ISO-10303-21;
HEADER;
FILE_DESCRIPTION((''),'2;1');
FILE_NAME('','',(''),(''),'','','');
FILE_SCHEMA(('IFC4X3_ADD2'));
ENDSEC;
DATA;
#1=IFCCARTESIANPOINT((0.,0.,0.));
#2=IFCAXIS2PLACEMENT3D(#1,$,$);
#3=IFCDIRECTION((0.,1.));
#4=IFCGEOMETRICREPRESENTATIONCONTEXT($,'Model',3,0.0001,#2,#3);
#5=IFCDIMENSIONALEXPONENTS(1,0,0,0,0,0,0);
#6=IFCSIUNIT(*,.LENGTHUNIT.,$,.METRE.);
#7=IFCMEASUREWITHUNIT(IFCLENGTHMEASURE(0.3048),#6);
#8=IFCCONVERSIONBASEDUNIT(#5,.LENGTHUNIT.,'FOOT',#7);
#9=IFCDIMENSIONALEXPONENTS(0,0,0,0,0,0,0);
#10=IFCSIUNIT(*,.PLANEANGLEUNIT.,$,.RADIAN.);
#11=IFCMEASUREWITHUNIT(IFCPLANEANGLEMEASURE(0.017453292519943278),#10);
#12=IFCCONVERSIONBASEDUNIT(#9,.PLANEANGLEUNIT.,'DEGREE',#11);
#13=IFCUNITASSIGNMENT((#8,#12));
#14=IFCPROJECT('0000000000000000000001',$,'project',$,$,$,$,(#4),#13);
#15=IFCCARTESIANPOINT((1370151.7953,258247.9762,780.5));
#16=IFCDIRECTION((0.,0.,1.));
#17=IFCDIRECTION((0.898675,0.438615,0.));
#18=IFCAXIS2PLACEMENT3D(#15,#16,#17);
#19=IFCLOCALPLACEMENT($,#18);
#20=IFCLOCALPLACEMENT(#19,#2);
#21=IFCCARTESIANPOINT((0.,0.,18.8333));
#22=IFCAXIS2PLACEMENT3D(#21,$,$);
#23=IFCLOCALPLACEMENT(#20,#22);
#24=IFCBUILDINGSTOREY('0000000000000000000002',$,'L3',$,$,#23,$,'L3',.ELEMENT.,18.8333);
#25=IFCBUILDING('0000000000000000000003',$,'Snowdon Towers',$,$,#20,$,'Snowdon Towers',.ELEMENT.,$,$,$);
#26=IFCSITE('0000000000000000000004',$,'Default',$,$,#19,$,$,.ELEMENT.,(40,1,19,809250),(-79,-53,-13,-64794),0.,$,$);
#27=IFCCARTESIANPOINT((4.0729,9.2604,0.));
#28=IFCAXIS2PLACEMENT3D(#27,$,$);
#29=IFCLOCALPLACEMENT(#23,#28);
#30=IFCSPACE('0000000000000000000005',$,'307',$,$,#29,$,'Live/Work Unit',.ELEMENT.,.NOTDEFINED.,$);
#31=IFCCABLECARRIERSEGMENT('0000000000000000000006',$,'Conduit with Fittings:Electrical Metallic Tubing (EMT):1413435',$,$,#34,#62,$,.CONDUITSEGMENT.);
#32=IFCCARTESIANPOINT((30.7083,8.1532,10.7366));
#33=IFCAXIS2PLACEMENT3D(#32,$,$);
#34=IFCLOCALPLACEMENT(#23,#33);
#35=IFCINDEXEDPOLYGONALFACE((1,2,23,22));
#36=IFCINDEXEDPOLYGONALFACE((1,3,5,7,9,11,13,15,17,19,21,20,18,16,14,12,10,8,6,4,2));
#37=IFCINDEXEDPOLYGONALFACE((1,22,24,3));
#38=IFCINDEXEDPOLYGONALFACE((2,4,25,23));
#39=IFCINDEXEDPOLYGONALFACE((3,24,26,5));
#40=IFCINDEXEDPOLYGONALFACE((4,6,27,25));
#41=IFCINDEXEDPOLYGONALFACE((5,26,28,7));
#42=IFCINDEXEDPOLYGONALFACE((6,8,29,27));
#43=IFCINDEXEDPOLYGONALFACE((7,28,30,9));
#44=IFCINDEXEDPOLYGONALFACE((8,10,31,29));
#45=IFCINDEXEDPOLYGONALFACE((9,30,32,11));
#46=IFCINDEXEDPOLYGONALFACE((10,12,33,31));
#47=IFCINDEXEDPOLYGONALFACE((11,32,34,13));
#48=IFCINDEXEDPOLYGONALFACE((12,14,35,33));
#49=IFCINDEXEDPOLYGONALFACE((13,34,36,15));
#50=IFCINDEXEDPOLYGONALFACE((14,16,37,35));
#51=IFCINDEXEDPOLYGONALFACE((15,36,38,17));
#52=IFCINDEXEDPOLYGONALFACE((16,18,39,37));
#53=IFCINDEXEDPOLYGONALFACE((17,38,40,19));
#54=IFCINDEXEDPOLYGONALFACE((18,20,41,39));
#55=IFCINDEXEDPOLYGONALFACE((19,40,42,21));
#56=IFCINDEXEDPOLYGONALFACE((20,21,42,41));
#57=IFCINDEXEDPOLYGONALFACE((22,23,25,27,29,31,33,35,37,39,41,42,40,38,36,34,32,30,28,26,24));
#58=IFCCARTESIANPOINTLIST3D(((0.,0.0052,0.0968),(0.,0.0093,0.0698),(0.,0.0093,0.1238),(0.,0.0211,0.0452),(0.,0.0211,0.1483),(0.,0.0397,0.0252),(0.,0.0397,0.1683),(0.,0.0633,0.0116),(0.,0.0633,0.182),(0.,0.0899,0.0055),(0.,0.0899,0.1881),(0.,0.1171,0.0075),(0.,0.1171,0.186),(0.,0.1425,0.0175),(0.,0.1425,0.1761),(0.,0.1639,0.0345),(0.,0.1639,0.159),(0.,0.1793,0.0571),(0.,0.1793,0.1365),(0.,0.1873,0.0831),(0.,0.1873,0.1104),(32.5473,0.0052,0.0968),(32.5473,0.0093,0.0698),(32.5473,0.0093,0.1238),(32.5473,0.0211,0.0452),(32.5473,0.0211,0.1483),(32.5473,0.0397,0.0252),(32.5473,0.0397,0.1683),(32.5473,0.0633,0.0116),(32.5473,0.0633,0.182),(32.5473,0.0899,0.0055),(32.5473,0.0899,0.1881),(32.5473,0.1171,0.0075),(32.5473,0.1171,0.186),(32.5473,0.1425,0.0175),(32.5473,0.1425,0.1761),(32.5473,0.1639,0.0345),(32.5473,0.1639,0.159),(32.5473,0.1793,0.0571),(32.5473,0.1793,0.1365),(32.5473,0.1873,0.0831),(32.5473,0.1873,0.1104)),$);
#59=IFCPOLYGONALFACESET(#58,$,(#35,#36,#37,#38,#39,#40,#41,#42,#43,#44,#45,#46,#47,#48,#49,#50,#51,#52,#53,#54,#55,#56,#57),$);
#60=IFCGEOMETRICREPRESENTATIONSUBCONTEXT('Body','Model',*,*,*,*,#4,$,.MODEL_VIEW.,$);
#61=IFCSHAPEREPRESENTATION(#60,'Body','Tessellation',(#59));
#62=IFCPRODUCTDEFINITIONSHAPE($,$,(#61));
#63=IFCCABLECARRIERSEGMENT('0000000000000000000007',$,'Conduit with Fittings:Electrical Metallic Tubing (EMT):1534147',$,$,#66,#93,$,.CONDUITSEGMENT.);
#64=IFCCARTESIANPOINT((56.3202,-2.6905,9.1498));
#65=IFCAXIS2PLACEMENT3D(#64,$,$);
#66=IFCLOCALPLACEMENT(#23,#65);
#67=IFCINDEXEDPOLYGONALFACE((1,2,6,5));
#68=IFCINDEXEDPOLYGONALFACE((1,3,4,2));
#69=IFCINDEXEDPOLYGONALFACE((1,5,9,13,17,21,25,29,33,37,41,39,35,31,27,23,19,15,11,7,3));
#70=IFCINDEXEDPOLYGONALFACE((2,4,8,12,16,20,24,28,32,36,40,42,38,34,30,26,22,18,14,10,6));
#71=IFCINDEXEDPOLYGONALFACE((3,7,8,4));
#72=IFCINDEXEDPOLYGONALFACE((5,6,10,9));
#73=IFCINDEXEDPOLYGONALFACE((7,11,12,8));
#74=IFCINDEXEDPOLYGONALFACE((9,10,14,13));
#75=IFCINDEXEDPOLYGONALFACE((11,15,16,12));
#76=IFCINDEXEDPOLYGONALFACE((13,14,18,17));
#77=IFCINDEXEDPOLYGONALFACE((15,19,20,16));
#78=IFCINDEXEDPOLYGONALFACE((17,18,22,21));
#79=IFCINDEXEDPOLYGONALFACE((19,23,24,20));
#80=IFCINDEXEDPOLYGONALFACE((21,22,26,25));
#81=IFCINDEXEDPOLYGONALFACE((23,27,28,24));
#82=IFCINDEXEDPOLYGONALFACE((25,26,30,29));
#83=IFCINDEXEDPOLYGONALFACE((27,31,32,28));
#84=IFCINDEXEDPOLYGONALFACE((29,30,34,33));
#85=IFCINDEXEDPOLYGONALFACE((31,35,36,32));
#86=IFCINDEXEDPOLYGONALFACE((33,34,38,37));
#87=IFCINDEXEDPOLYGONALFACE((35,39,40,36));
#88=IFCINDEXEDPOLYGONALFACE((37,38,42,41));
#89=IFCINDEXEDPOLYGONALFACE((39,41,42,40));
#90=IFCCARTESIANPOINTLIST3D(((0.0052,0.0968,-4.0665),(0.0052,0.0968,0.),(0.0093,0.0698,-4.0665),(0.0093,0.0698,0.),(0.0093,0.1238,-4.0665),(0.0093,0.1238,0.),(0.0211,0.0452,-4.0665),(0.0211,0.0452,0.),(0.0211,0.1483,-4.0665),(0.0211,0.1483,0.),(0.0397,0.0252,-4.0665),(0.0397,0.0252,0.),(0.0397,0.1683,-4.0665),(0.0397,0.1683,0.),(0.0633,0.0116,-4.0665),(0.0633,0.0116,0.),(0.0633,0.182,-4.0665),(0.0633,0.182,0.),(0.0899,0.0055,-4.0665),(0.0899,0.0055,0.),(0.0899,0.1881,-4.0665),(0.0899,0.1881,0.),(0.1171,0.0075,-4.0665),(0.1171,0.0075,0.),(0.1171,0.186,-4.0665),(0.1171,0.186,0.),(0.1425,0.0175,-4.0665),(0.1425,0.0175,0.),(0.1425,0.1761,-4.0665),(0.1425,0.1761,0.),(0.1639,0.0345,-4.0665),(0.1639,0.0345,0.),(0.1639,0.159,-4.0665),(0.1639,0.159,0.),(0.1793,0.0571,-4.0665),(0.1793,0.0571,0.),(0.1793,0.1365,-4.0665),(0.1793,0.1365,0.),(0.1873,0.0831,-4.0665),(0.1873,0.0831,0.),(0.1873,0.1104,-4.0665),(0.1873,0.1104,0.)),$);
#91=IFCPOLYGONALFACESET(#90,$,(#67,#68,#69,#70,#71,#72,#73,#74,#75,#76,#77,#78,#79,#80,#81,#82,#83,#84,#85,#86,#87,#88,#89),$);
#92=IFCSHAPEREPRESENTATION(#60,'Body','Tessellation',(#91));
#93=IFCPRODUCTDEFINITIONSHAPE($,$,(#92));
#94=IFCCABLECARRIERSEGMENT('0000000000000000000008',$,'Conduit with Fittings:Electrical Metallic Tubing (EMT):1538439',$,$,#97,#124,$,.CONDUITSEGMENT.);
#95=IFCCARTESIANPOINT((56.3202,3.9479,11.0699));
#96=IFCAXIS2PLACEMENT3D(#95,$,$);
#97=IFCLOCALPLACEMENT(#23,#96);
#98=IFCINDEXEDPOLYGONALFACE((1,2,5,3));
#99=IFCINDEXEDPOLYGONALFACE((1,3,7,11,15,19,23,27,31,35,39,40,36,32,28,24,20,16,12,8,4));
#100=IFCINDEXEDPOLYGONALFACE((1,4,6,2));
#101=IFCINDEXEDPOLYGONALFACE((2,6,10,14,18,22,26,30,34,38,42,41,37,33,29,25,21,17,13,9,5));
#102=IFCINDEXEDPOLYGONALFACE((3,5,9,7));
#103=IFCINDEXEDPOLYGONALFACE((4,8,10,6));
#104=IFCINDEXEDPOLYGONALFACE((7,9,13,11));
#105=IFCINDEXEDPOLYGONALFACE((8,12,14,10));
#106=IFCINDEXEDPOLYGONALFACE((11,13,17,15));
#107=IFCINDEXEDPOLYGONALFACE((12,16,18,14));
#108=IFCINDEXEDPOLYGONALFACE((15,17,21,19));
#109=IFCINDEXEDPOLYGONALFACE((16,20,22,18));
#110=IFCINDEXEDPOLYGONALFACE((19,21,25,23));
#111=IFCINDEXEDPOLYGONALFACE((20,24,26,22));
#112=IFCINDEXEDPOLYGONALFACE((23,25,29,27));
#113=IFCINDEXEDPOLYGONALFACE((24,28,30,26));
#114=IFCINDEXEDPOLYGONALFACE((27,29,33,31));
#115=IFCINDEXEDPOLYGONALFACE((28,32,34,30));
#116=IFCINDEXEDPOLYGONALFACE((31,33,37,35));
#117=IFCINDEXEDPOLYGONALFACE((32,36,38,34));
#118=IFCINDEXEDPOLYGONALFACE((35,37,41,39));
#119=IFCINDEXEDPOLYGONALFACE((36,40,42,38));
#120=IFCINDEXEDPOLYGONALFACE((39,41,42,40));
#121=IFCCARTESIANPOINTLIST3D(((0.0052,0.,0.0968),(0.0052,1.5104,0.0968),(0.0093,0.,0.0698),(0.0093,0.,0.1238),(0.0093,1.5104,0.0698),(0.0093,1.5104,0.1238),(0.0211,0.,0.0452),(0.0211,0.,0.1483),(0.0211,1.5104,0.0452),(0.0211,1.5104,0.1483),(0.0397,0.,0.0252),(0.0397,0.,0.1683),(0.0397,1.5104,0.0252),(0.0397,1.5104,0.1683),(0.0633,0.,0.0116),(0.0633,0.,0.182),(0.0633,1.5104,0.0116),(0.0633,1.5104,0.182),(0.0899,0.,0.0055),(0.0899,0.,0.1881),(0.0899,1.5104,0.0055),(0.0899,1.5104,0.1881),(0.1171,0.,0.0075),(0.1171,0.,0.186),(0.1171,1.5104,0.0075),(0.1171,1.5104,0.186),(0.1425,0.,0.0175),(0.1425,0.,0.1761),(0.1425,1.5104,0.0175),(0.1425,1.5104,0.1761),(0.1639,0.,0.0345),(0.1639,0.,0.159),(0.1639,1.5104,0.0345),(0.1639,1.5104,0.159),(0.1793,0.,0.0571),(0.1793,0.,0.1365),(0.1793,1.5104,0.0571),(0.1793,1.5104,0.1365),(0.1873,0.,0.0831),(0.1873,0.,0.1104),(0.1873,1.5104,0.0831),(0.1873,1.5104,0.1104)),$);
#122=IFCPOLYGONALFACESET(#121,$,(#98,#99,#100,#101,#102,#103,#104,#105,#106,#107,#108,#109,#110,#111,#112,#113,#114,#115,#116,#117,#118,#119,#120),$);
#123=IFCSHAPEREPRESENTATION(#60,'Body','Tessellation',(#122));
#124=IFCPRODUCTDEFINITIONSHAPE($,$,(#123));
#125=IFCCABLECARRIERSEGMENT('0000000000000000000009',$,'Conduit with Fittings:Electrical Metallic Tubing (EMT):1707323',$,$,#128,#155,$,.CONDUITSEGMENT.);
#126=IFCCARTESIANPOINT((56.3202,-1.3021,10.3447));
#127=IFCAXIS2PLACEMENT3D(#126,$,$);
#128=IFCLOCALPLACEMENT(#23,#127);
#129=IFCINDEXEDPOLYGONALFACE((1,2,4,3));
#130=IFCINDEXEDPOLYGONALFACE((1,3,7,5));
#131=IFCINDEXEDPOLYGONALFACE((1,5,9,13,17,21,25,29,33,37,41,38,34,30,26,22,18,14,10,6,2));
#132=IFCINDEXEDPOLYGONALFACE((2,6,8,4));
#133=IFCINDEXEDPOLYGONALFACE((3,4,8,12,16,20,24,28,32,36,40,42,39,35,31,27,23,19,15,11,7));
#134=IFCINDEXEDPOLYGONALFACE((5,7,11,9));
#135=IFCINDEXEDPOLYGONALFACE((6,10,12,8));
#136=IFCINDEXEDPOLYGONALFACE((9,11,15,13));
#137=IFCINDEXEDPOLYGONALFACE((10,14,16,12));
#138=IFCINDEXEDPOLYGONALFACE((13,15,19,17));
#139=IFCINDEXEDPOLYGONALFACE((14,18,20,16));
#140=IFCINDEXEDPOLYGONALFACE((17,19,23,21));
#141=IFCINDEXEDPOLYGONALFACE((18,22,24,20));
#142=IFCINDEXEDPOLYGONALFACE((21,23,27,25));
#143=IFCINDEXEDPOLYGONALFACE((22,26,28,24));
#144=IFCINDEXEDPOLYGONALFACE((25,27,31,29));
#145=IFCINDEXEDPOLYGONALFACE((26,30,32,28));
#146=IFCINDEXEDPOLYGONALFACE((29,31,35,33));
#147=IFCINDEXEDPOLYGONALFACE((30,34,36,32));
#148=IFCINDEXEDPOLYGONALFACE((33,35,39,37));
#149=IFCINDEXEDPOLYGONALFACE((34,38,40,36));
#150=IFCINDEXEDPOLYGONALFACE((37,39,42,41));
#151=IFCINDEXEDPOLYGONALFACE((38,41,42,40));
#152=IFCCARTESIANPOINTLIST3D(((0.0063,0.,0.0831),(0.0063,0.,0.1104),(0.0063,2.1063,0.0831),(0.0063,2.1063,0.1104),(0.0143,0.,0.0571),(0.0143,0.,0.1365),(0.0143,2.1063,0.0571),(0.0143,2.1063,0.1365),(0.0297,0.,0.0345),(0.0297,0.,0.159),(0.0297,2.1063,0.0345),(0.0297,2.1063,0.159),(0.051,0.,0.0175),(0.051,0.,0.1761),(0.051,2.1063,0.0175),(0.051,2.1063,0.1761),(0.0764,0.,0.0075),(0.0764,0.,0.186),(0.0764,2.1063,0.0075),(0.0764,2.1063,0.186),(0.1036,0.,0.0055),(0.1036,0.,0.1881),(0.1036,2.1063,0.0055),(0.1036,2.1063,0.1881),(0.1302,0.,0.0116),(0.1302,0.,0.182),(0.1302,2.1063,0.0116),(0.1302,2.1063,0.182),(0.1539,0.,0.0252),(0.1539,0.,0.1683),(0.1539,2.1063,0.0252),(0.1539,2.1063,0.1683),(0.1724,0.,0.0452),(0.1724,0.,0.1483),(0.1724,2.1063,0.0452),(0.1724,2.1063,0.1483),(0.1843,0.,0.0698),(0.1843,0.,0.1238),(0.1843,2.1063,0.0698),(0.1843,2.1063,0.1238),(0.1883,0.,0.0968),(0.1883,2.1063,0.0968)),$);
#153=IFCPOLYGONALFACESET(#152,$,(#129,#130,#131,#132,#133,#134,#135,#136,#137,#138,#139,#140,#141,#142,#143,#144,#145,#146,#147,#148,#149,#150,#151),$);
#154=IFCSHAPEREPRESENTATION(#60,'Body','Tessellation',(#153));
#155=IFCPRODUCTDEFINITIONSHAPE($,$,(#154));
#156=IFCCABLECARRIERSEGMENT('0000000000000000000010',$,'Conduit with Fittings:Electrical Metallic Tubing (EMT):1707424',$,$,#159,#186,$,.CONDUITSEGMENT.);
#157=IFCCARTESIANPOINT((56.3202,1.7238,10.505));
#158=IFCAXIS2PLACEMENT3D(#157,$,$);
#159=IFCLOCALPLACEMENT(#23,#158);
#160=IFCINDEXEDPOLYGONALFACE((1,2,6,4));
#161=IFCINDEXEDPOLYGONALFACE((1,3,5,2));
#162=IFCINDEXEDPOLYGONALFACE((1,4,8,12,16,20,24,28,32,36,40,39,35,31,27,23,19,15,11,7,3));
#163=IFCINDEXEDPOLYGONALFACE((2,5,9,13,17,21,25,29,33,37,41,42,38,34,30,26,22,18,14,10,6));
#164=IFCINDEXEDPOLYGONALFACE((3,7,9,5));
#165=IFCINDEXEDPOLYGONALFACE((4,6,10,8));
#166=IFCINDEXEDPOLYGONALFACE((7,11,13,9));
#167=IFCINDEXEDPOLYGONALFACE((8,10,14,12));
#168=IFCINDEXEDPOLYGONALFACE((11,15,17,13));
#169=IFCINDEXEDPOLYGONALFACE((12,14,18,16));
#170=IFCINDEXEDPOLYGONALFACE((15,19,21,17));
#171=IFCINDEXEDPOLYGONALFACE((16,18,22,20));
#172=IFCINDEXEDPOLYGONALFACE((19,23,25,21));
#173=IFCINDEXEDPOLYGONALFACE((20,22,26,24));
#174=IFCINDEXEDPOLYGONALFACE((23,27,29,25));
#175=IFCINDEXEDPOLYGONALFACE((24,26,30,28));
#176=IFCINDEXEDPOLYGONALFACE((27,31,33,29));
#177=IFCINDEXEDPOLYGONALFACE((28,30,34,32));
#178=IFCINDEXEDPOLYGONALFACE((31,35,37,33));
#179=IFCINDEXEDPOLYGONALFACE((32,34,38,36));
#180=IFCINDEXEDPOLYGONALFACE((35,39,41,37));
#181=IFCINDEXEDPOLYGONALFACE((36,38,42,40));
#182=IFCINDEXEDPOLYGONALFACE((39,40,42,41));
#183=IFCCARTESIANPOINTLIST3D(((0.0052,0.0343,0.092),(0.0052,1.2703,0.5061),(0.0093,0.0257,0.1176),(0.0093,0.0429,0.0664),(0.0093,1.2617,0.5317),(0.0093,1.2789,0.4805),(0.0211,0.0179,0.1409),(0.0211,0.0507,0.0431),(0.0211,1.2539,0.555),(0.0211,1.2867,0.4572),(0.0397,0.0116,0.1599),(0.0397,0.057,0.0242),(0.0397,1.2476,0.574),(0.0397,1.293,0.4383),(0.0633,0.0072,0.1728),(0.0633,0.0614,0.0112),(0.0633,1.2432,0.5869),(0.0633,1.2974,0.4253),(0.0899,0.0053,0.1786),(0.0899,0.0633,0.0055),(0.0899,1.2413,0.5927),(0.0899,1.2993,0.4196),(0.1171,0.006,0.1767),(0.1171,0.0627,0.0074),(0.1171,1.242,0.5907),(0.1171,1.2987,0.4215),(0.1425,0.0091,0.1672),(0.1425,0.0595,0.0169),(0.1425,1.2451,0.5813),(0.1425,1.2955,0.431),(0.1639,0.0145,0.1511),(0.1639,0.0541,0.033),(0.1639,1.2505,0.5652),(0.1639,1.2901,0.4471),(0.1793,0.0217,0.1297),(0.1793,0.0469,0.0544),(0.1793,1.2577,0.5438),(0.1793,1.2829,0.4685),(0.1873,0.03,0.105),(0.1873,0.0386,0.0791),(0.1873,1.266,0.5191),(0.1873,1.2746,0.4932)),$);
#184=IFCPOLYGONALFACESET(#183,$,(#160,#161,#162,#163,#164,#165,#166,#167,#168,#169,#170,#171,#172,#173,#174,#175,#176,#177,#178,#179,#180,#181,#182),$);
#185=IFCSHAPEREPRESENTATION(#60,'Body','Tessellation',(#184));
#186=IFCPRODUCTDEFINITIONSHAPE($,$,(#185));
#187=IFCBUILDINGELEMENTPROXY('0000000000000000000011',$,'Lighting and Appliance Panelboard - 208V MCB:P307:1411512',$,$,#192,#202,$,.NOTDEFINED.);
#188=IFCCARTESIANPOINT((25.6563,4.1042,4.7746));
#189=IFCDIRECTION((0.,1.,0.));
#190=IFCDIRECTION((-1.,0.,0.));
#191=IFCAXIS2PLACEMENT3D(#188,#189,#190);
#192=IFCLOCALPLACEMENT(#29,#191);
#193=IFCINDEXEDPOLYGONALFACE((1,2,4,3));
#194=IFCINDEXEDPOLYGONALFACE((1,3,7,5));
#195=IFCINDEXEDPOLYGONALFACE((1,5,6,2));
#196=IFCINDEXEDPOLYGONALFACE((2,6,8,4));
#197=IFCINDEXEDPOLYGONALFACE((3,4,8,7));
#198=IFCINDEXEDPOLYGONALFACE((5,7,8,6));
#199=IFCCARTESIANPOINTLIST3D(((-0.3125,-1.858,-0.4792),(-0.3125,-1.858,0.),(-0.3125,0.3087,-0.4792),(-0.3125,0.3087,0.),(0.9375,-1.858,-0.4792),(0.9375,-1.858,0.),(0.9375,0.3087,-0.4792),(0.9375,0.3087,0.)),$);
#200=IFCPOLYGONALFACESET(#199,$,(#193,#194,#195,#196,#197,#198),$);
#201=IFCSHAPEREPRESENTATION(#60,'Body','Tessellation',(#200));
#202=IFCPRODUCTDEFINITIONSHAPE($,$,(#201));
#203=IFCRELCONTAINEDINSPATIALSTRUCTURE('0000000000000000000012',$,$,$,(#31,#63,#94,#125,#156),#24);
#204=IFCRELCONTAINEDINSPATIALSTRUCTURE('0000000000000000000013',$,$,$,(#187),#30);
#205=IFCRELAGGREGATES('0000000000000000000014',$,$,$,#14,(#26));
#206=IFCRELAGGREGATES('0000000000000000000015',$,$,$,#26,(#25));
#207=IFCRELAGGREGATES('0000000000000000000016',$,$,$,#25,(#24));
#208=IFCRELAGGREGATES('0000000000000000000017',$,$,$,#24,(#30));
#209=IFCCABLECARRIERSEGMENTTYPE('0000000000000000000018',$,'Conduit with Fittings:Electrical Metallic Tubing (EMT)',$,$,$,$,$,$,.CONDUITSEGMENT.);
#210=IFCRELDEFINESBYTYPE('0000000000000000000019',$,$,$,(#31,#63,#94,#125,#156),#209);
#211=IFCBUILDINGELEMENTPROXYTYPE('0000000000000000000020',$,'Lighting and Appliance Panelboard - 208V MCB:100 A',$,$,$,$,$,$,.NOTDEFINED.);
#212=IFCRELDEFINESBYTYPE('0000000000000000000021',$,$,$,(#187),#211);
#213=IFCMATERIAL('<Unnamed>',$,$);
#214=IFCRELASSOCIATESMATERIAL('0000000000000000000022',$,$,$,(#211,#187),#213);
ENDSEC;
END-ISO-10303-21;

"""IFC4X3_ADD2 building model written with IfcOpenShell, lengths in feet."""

from ifc_helpers import new_model, entity, si_unit, converted_unit, direction, frame, frame_2d, origin, origin_2d_with_axis, place, context, subcontext, project, spatial, rectangle, circle, extrude, source, transform, mapped, material, type_object, type_shapes, element, save


model = new_model("IFC4X3_ADD2")

# Units and contexts
model_context = context("Model", 3, precision=0.0001, world=origin(), true_north=direction((0.0, 1.0)))
body_context = subcontext(model_context, "Body", "Model", "MODEL_VIEW")
ifc_project = project(units=[converted_unit("LENGTHUNIT", "FOOT", entity("IfcLengthMeasure", 0.3048), si_unit("LENGTHUNIT", "METRE"), dimensions=[1, 0, 0, 0, 0, 0, 0]), converted_unit("PLANEANGLEUNIT", "DEGREE", entity("IfcPlaneAngleMeasure", 0.017453292519943278), si_unit("PLANEANGLEUNIT", "RADIAN"), dimensions=[0, 0, 0, 0, 0, 0, 0])], contexts=[model_context])

# Site, building, storey
site_placement = place(None, frame((1370151.7953, 258247.9762, 780.5), z_axis=(0.0, 0.0, 1.0), x_axis=(0.898675, 0.438615, 0.0)))
site = spatial("IfcSite", under=ifc_project, at=site_placement, Name="Default", CompositionType="ELEMENT", RefLatitude=(40, 1, 19, 809250), RefLongitude=(-79, -53, -13, -64794), RefElevation=0.0)
building_placement = place(site_placement, origin())
building = spatial("IfcBuilding", under=site, at=building_placement, Name="Snowdon Towers", LongName="Snowdon Towers", CompositionType="ELEMENT")
storey_placement = place(building_placement, frame((0.0, 0.0, 18.8333)))
storey = spatial("IfcBuildingStorey", under=building, at=storey_placement, Name="L3", LongName="L3", CompositionType="ELEMENT", Elevation=18.8333)

# Cable carrier segments
cable_carrier_segment_type = type_object("IfcCableCarrierSegmentType", Name="Conduit with Fittings:Electrical Metallic Tubing (EMT)", PredefinedType="CONDUITSEGMENT")
cable_carrier_segment_1_placement = place(storey_placement, frame((30.7083, 8.1532, 10.7366)))
element("IfcCableCarrierSegment", 1, at=cable_carrier_segment_1_placement, inside=storey, type_object=cable_carrier_segment_type, Name="Conduit with Fittings:Electrical Metallic Tubing (EMT):1413435", PredefinedType="CONDUITSEGMENT", context=body_context, shape_type="SweptSolid", body=[
    extrude(circle(Radius=0.0915, at=origin_2d_with_axis()), frame((0.0, 0.0968, 0.0968), z_axis=(1.0, 0.0, 0.0), x_axis=(0.0, -1.0, 0.0)), (0.0, 0.0, 1.0), 32.5473),
])
cable_carrier_segment_2_placement = place(storey_placement, frame((56.3202, -2.6905, 9.1498)))
element("IfcCableCarrierSegment", 2, at=cable_carrier_segment_2_placement, inside=storey, type_object=cable_carrier_segment_type, Name="Conduit with Fittings:Electrical Metallic Tubing (EMT):1534147", PredefinedType="CONDUITSEGMENT", context=body_context, shape_type="SweptSolid", body=[
    extrude(circle(Radius=0.0915, at=frame_2d((0.0, 0.0), x_axis=(1.0, 0.0))), frame((0.0968, 0.0968, -4.0665), z_axis=(0.0, 0.0, 1.0), x_axis=(-1.0, 0.0, 0.0)), (0.0, 0.0, 1.0), 4.0665),
])
cable_carrier_segment_3_placement = place(storey_placement, frame((56.3202, 3.9479, 11.0699)))
element("IfcCableCarrierSegment", 3, at=cable_carrier_segment_3_placement, inside=storey, type_object=cable_carrier_segment_type, Name="Conduit with Fittings:Electrical Metallic Tubing (EMT):1538439", PredefinedType="CONDUITSEGMENT", context=body_context, shape_type="SweptSolid", body=[
    extrude(circle(Radius=0.0915, at=origin_2d_with_axis()), frame((0.0968, 0.0, 0.0968), z_axis=(0.0, 1.0, 0.0), x_axis=(-1.0, 0.0, 0.0)), (0.0, 0.0, 1.0), 1.5104),
])
cable_carrier_segment_4_placement = place(storey_placement, frame((56.3202, -1.3021, 10.3447)))
element("IfcCableCarrierSegment", 4, at=cable_carrier_segment_4_placement, inside=storey, type_object=cable_carrier_segment_type, Name="Conduit with Fittings:Electrical Metallic Tubing (EMT):1707323", PredefinedType="CONDUITSEGMENT", context=body_context, shape_type="SweptSolid", body=[
    extrude(circle(Radius=0.0915, at=origin_2d_with_axis()), frame((0.0968, 0.0, 0.0968), z_axis=(0.0, 1.0, 0.0), x_axis=(1.0, 0.0, 0.0)), (0.0, 0.0, 1.0), 2.1063),
])
cable_carrier_segment_5_placement = place(storey_placement, frame((56.3202, 1.7238, 10.505)))
element("IfcCableCarrierSegment", 5, at=cable_carrier_segment_5_placement, inside=storey, type_object=cable_carrier_segment_type, Name="Conduit with Fittings:Electrical Metallic Tubing (EMT):1707424", PredefinedType="CONDUITSEGMENT", context=body_context, shape_type="SweptSolid", body=[
    extrude(circle(Radius=0.0915, at=origin_2d_with_axis()), frame((0.0968, 0.0343, 0.092), z_axis=(0.0, 0.948201, 0.317671), x_axis=(-1.0, 0.0, 0.0)), (0.0, 0.0, 1.0), 1.3035),
])

# Shared definitions
space_1_placement = place(storey_placement, frame((4.0729, 9.2604, 0.0)))
space_1 = spatial("IfcSpace", under=storey, at=space_1_placement, Name="307", LongName="Live/Work Unit", CompositionType="ELEMENT", PredefinedType="NOTDEFINED")

# Building element proxy
ifc_material_1 = material(Name="<Unnamed>")
building_element_proxy_type_1 = type_object("IfcBuildingElementProxyType", Name="Lighting and Appliance Panelboard - 208V MCB:100 A", PredefinedType="NOTDEFINED", material=ifc_material_1)
shared_shape_1 = source(origin(), body_context, "Body", "SweptSolid", [
    extrude(rectangle(XDim=1.25, YDim=2.1667, at=origin_2d_with_axis()), frame((0.3125, -0.7746, -0.4792), z_axis=(0.0, 0.0, 1.0), x_axis=(-1.0, 0.0, 0.0)), (0.0, 0.0, 1.0), 0.4792),
])
type_shapes(building_element_proxy_type_1, [shared_shape_1])
proxy_1_placement = place(space_1_placement, frame((25.6563, 4.1042, 4.7746), z_axis=(0.0, 1.0, 0.0), x_axis=(-1.0, 0.0, 0.0)))
element("IfcBuildingElementProxy", 6, at=proxy_1_placement, inside=space_1, type_object=building_element_proxy_type_1, material=ifc_material_1, Name="Lighting and Appliance Panelboard - 208V MCB:P307:1411512", PredefinedType="NOTDEFINED", context=body_context, shape_type="MappedRepresentation", body=[
    mapped(shared_shape_1, transform((0.0, 0.0, 0.0), scale=1.0)),
])

save(model, "model.ifc")
